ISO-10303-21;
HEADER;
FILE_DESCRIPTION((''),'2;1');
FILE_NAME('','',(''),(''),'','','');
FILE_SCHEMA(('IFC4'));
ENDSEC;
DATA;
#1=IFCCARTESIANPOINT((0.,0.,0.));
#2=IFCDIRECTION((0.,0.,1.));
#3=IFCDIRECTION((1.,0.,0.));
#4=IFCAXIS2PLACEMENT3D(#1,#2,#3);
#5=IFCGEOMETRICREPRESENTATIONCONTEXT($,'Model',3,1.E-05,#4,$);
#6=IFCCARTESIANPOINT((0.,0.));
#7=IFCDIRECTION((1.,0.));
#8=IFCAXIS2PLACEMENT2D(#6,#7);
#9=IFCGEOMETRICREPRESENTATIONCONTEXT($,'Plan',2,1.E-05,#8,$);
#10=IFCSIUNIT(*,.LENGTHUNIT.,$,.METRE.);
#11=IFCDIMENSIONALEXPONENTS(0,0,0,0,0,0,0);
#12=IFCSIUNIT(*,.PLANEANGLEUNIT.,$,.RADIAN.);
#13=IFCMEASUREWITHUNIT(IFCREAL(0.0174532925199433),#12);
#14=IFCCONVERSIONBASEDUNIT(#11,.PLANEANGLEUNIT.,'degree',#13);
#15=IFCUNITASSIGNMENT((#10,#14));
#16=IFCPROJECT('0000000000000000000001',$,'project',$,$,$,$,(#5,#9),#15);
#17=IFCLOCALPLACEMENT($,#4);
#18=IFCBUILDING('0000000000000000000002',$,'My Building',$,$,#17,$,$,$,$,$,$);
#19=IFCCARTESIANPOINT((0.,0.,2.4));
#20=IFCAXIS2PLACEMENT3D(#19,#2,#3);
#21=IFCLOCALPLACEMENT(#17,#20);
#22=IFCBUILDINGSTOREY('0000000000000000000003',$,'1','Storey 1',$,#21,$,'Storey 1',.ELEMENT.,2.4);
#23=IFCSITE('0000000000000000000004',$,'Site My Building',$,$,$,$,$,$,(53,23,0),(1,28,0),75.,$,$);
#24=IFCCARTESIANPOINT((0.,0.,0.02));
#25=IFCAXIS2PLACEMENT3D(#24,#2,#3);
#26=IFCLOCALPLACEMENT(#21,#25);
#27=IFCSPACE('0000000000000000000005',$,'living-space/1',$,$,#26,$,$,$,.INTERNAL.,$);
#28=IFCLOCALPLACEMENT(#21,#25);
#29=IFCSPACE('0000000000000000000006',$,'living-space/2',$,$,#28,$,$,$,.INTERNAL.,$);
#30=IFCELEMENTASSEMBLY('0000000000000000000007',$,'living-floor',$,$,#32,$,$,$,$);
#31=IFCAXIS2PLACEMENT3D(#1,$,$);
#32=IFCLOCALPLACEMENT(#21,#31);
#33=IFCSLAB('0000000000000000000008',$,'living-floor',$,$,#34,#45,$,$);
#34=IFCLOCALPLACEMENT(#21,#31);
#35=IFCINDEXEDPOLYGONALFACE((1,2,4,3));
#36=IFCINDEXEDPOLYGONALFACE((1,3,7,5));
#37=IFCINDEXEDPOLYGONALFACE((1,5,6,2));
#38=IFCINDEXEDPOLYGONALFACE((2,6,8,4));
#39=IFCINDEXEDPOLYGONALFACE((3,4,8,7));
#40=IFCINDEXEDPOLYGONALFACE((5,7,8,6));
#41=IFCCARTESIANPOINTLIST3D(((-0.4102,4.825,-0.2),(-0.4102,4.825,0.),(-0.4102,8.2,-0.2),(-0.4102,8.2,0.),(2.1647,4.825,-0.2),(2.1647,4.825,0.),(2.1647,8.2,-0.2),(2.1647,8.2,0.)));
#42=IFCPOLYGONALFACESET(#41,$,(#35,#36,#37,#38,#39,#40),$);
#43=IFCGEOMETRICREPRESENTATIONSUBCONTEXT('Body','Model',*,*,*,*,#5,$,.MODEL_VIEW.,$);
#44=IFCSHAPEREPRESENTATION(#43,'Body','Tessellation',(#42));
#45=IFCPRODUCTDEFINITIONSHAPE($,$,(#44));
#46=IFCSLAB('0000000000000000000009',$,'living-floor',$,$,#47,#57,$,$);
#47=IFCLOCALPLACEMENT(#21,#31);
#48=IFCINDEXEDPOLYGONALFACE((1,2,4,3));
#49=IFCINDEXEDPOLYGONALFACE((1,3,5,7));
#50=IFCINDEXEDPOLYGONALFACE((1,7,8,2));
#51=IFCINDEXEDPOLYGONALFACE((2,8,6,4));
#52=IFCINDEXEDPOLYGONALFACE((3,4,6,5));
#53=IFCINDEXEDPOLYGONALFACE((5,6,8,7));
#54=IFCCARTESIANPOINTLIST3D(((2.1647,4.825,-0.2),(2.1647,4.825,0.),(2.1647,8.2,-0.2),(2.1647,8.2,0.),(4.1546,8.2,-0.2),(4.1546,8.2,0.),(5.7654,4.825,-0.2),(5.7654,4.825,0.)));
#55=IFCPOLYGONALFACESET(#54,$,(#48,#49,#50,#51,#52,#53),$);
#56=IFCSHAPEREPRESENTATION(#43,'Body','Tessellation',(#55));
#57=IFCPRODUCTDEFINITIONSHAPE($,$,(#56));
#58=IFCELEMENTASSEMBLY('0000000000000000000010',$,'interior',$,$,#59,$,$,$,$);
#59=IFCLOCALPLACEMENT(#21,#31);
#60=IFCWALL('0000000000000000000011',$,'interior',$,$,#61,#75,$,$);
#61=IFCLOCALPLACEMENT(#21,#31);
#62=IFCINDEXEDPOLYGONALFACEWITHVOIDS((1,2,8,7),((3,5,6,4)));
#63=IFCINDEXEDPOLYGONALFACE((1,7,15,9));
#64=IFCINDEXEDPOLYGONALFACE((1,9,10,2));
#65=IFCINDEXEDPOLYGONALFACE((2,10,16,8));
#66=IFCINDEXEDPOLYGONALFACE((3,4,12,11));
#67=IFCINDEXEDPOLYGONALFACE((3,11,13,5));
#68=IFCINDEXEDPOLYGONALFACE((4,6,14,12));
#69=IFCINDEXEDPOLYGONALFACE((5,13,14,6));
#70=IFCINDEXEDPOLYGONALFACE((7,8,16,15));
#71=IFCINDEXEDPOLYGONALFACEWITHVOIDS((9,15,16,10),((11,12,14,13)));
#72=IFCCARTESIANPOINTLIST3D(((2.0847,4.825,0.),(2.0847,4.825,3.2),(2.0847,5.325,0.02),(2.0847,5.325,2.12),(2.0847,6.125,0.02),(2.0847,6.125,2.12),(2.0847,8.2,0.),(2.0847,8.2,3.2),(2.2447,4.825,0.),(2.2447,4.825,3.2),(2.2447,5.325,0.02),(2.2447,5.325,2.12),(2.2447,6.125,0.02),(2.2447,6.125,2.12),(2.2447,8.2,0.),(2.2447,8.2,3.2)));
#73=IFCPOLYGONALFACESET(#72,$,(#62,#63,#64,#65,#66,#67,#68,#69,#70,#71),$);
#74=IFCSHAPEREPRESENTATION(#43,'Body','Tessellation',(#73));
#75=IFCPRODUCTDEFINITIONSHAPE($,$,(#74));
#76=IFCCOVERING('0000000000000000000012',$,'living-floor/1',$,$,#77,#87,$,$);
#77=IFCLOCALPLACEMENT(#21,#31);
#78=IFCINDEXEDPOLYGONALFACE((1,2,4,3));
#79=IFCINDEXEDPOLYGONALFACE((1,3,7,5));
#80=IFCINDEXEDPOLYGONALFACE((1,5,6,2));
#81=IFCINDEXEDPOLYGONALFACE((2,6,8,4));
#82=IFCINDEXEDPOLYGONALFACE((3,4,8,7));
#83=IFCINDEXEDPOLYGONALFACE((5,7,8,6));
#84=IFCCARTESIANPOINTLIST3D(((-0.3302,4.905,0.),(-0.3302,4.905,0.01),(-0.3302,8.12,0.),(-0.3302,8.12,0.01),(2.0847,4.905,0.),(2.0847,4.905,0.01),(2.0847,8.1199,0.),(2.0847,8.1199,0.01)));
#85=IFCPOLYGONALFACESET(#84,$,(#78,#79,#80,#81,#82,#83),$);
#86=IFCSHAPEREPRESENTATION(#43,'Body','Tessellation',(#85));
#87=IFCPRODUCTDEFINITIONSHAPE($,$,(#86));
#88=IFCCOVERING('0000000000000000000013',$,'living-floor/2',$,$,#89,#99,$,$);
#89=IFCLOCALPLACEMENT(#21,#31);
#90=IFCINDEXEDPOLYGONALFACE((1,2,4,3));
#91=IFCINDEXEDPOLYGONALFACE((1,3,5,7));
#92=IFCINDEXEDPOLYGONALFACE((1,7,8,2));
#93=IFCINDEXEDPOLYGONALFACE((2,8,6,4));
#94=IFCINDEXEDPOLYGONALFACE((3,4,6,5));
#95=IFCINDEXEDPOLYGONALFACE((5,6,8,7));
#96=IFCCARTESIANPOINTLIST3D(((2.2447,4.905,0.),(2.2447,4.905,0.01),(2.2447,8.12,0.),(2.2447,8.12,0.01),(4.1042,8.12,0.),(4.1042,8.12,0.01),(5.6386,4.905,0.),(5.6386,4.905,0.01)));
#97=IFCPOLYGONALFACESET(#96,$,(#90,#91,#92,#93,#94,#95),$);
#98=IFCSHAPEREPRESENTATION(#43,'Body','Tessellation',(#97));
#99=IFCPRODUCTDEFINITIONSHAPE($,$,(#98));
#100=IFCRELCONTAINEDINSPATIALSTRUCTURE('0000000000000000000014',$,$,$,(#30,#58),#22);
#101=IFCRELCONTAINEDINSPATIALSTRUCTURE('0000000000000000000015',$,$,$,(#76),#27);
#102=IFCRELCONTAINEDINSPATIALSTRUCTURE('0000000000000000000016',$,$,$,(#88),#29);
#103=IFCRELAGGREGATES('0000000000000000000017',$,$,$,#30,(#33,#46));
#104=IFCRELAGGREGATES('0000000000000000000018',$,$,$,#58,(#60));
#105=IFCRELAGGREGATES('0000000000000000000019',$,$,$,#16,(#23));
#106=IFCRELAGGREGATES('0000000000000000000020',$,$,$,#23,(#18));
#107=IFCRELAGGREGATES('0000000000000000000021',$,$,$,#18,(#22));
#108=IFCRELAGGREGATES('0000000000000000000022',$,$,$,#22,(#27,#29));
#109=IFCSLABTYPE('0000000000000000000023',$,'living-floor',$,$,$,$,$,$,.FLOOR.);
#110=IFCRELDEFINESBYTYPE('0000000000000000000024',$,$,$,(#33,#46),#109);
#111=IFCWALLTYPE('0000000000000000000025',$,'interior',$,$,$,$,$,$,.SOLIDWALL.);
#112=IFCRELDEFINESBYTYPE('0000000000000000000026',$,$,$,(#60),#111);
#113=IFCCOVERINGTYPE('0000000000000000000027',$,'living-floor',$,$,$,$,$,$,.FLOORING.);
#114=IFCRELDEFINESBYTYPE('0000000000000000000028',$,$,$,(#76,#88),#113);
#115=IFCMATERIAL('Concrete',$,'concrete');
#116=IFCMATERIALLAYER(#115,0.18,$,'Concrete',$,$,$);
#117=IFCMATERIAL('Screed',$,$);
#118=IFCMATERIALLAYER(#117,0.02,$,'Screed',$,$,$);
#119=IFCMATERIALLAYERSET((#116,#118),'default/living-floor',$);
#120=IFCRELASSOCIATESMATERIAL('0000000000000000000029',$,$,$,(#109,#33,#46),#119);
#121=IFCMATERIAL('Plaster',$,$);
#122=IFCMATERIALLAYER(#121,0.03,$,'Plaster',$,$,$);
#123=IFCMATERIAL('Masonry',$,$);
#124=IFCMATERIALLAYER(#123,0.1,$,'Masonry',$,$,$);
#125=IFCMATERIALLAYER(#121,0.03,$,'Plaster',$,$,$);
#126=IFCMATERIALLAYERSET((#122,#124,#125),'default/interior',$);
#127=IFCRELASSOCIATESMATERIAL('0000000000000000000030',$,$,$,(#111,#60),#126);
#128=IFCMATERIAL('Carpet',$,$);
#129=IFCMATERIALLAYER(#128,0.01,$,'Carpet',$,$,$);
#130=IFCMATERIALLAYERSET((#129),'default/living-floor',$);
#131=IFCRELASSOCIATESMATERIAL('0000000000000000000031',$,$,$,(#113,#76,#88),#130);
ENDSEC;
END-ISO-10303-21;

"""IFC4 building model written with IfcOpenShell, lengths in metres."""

from ifc_helpers import new_model, entity, si_unit, converted_unit, frame, origin, origin_with_axes, origin_2d_with_axis, place, context, subcontext, project, spatial, polyline, outline, extrude, material, layer, layer_set, layer_usage, type_object, element, aggregate, save


model = new_model("IFC4")

# Units and contexts
model_context = context("Model", 3, precision=1e-05, world=origin_with_axes())
plan_context = context("Plan", 2, precision=1e-05, world=origin_2d_with_axis())
body_context = subcontext(model_context, "Body", "Model", "MODEL_VIEW")
ifc_project = project(units=[si_unit("LENGTHUNIT", "METRE"), converted_unit("PLANEANGLEUNIT", "degree", entity("IfcReal", 0.0174532925199433), si_unit("PLANEANGLEUNIT", "RADIAN"), dimensions=[0, 0, 0, 0, 0, 0, 0])], contexts=[model_context, plan_context])

# Site, building, storey
site = spatial("IfcSite", under=ifc_project, Name="Site My Building", RefLatitude=(53, 23, 0), RefLongitude=(1, 28, 0), RefElevation=75.0)
building_placement = place(None, origin_with_axes())
building = spatial("IfcBuilding", under=site, at=building_placement, Name="My Building")
storey_placement = place(building_placement, frame((0.0, 0.0, 2.4), z_axis=(0.0, 0.0, 1.0), x_axis=(1.0, 0.0, 0.0)))
storey = spatial("IfcBuildingStorey", under=building, at=storey_placement, Name="1", Description="Storey 1", LongName="Storey 1", CompositionType="ELEMENT", Elevation=2.4)

# Element assembly, slabs
assembly_1_placement = place(storey_placement, frame((0.0, 0.0, -2.4), z_axis=(0.0, 0.0, 1.0), x_axis=(1.0, 0.0, 0.0)))
assembly_1 = element("IfcElementAssembly", 1, at=assembly_1_placement, inside=storey, Name="living-floor")
ifc_material_1 = material(Name="Concrete", Category="concrete")
ifc_layer_1 = layer(ifc_material_1, 0.18, Name="Concrete")
ifc_material_2 = material(Name="Screed")
ifc_layer_2 = layer(ifc_material_2, 0.02, Name="Screed")
ifc_layer_set_1 = layer_set([ifc_layer_1, ifc_layer_2], Name="default/living-floor")
ifc_layer_usage_1 = layer_usage(ifc_layer_set_1, "AXIS3", "POSITIVE", 0.0)
slab_type = type_object("IfcSlabType", Name="living-floor", PredefinedType="FLOOR", material=ifc_layer_set_1)
slab_1_placement = place(assembly_1_placement, frame((2.1647, 8.2, 2.2), z_axis=(0.0, 0.0, 1.0), x_axis=(1.0, 0.0, 0.0)))
slab_1 = element("IfcSlab", 2, at=slab_1_placement, type_object=slab_type, material=ifc_layer_usage_1, Name="living-floor", context=body_context, shape_type="SweptSolid", body=[
    extrude(outline(polyline([(0.0, 0.0), (-2.5749, 0.0), (-2.5749, -3.375), (0.0, -3.375), (0.0, 0.0)])), origin(), (0.0, 0.0, 1.0), 0.2),
])
ifc_layer_usage_2 = layer_usage(ifc_layer_set_1, "AXIS3", "POSITIVE", 0.0)
slab_2_placement = place(assembly_1_placement, frame((2.1647, 8.2, 2.2), z_axis=(0.0, 0.0, 1.0), x_axis=(1.0, 0.0, 0.0)))
slab_2 = element("IfcSlab", 3, at=slab_2_placement, type_object=slab_type, material=ifc_layer_usage_2, Name="living-floor", context=body_context, shape_type="SweptSolid", body=[
    extrude(outline(polyline([(0.0, 0.0), (0.0, -3.375), (3.6007, -3.375), (1.99, 0.0), (0.0, 0.0)])), origin(), (0.0, 0.0, 1.0), 0.2),
])
aggregate(assembly_1, [slab_1, slab_2])

# Element assembly, wall, opening
assembly_2_placement = place(storey_placement, frame((2.1647, 4.825, 0.0), z_axis=(0.0, 0.0, 1.0), x_axis=(0.0, 1.0, 0.0)))
assembly_2 = element("IfcElementAssembly", 4, at=assembly_2_placement, inside=storey, Name="interior")
ifc_material_3 = material(Name="Plaster")
ifc_layer_3 = layer(ifc_material_3, 0.03, Name="Plaster")
ifc_material_4 = material(Name="Masonry")
ifc_layer_4 = layer(ifc_material_4, 0.1, Name="Masonry")
ifc_layer_5 = layer(ifc_material_3, 0.03, Name="Plaster")
ifc_layer_set_2 = layer_set([ifc_layer_3, ifc_layer_4, ifc_layer_5], Name="default/interior")
ifc_layer_usage_3 = layer_usage(ifc_layer_set_2, "AXIS2", "POSITIVE", -0.08)
wall_type_1 = type_object("IfcWallType", Name="interior", PredefinedType="SOLIDWALL", material=ifc_layer_set_2)
wall_1_placement = place(assembly_2_placement, origin_with_axes())
wall_1 = element("IfcWall", 5, at=wall_1_placement, type_object=wall_type_1, material=ifc_layer_usage_3, Name="interior", context=body_context, shape_type="SweptSolid", body=[
    extrude(outline(polyline([(0.0, 0.08), (0.0, -0.08), (3.375, -0.08), (3.375, 0.08), (0.0, 0.08)])), origin(), (0.0, 0.0, 1.0), 3.2),
])
opening_placement = place(wall_1_placement, frame((0.5, -0.08, 0.02), z_axis=(0.0, 0.0, 1.0), x_axis=(1.0, 0.0, 0.0)))
element("IfcOpeningElement", 6, at=opening_placement, cuts=wall_1, PredefinedType="OPENING", context=body_context, shape_type="SweptSolid", body=[
    extrude(outline(polyline([(0.0, 0.0), (0.8, 0.0), (0.8, 2.1), (0.0, 2.1), (0.0, 0.0)])), frame((0.0, -0.02, 0.0), z_axis=(0.0, -1.0, 0.0), x_axis=(1.0, 0.0, 0.0)), (0.0, 0.0, -1.0), 0.2),
])
aggregate(assembly_2, [wall_1])

# Shared definitions
space_1_placement = place(storey_placement, frame((0.0, 0.0, 0.02), z_axis=(0.0, 0.0, 1.0), x_axis=(1.0, 0.0, 0.0)))
space_1 = spatial("IfcSpace", under=storey, at=space_1_placement, Name="living-space/1", PredefinedType="INTERNAL")

# Covering
ifc_material_5 = material(Name="Carpet")
ifc_layer_6 = layer(ifc_material_5, 0.01, Name="Carpet")
ifc_layer_set_3 = layer_set([ifc_layer_6], Name="default/living-floor")
ifc_layer_usage_4 = layer_usage(ifc_layer_set_3, "AXIS2", "POSITIVE", 0.0)
covering_type = type_object("IfcCoveringType", Name="living-floor", PredefinedType="FLOORING", material=ifc_layer_set_3)
covering_1_placement = place(space_1_placement, frame((0.0, 0.0, -0.02), z_axis=(0.0, 0.0, 1.0), x_axis=(1.0, 0.0, 0.0)))
element("IfcCovering", 7, at=covering_1_placement, inside=space_1, type_object=covering_type, material=ifc_layer_usage_4, Name="living-floor/1", context=body_context, shape_type="SweptSolid", body=[
    extrude(outline(polyline([(-0.3302, 4.905), (2.0847, 4.905), (2.0847, 8.1199), (-0.3302, 8.12), (-0.3302, 4.905)])), origin_with_axes(), (0.0, 0.0, 1.0), 0.01),
])

# Shared definitions
space_2_placement = place(storey_placement, frame((0.0, 0.0, 0.02), z_axis=(0.0, 0.0, 1.0), x_axis=(1.0, 0.0, 0.0)))
space_2 = spatial("IfcSpace", under=storey, at=space_2_placement, Name="living-space/2", PredefinedType="INTERNAL")

# Covering
ifc_layer_usage_5 = layer_usage(ifc_layer_set_3, "AXIS2", "POSITIVE", 0.0)
covering_2_placement = place(space_2_placement, frame((0.0, 0.0, -0.02), z_axis=(0.0, 0.0, 1.0), x_axis=(1.0, 0.0, 0.0)))
element("IfcCovering", 8, at=covering_2_placement, inside=space_2, type_object=covering_type, material=ifc_layer_usage_5, Name="living-floor/2", context=body_context, shape_type="SweptSolid", body=[
    extrude(outline(polyline([(5.6386, 4.905), (4.1042, 8.12), (2.2447, 8.12), (2.2447, 4.905), (5.6386, 4.905)])), origin_with_axes(), (0.0, 0.0, 1.0), 0.01),
])

save(model, "model.ifc")
